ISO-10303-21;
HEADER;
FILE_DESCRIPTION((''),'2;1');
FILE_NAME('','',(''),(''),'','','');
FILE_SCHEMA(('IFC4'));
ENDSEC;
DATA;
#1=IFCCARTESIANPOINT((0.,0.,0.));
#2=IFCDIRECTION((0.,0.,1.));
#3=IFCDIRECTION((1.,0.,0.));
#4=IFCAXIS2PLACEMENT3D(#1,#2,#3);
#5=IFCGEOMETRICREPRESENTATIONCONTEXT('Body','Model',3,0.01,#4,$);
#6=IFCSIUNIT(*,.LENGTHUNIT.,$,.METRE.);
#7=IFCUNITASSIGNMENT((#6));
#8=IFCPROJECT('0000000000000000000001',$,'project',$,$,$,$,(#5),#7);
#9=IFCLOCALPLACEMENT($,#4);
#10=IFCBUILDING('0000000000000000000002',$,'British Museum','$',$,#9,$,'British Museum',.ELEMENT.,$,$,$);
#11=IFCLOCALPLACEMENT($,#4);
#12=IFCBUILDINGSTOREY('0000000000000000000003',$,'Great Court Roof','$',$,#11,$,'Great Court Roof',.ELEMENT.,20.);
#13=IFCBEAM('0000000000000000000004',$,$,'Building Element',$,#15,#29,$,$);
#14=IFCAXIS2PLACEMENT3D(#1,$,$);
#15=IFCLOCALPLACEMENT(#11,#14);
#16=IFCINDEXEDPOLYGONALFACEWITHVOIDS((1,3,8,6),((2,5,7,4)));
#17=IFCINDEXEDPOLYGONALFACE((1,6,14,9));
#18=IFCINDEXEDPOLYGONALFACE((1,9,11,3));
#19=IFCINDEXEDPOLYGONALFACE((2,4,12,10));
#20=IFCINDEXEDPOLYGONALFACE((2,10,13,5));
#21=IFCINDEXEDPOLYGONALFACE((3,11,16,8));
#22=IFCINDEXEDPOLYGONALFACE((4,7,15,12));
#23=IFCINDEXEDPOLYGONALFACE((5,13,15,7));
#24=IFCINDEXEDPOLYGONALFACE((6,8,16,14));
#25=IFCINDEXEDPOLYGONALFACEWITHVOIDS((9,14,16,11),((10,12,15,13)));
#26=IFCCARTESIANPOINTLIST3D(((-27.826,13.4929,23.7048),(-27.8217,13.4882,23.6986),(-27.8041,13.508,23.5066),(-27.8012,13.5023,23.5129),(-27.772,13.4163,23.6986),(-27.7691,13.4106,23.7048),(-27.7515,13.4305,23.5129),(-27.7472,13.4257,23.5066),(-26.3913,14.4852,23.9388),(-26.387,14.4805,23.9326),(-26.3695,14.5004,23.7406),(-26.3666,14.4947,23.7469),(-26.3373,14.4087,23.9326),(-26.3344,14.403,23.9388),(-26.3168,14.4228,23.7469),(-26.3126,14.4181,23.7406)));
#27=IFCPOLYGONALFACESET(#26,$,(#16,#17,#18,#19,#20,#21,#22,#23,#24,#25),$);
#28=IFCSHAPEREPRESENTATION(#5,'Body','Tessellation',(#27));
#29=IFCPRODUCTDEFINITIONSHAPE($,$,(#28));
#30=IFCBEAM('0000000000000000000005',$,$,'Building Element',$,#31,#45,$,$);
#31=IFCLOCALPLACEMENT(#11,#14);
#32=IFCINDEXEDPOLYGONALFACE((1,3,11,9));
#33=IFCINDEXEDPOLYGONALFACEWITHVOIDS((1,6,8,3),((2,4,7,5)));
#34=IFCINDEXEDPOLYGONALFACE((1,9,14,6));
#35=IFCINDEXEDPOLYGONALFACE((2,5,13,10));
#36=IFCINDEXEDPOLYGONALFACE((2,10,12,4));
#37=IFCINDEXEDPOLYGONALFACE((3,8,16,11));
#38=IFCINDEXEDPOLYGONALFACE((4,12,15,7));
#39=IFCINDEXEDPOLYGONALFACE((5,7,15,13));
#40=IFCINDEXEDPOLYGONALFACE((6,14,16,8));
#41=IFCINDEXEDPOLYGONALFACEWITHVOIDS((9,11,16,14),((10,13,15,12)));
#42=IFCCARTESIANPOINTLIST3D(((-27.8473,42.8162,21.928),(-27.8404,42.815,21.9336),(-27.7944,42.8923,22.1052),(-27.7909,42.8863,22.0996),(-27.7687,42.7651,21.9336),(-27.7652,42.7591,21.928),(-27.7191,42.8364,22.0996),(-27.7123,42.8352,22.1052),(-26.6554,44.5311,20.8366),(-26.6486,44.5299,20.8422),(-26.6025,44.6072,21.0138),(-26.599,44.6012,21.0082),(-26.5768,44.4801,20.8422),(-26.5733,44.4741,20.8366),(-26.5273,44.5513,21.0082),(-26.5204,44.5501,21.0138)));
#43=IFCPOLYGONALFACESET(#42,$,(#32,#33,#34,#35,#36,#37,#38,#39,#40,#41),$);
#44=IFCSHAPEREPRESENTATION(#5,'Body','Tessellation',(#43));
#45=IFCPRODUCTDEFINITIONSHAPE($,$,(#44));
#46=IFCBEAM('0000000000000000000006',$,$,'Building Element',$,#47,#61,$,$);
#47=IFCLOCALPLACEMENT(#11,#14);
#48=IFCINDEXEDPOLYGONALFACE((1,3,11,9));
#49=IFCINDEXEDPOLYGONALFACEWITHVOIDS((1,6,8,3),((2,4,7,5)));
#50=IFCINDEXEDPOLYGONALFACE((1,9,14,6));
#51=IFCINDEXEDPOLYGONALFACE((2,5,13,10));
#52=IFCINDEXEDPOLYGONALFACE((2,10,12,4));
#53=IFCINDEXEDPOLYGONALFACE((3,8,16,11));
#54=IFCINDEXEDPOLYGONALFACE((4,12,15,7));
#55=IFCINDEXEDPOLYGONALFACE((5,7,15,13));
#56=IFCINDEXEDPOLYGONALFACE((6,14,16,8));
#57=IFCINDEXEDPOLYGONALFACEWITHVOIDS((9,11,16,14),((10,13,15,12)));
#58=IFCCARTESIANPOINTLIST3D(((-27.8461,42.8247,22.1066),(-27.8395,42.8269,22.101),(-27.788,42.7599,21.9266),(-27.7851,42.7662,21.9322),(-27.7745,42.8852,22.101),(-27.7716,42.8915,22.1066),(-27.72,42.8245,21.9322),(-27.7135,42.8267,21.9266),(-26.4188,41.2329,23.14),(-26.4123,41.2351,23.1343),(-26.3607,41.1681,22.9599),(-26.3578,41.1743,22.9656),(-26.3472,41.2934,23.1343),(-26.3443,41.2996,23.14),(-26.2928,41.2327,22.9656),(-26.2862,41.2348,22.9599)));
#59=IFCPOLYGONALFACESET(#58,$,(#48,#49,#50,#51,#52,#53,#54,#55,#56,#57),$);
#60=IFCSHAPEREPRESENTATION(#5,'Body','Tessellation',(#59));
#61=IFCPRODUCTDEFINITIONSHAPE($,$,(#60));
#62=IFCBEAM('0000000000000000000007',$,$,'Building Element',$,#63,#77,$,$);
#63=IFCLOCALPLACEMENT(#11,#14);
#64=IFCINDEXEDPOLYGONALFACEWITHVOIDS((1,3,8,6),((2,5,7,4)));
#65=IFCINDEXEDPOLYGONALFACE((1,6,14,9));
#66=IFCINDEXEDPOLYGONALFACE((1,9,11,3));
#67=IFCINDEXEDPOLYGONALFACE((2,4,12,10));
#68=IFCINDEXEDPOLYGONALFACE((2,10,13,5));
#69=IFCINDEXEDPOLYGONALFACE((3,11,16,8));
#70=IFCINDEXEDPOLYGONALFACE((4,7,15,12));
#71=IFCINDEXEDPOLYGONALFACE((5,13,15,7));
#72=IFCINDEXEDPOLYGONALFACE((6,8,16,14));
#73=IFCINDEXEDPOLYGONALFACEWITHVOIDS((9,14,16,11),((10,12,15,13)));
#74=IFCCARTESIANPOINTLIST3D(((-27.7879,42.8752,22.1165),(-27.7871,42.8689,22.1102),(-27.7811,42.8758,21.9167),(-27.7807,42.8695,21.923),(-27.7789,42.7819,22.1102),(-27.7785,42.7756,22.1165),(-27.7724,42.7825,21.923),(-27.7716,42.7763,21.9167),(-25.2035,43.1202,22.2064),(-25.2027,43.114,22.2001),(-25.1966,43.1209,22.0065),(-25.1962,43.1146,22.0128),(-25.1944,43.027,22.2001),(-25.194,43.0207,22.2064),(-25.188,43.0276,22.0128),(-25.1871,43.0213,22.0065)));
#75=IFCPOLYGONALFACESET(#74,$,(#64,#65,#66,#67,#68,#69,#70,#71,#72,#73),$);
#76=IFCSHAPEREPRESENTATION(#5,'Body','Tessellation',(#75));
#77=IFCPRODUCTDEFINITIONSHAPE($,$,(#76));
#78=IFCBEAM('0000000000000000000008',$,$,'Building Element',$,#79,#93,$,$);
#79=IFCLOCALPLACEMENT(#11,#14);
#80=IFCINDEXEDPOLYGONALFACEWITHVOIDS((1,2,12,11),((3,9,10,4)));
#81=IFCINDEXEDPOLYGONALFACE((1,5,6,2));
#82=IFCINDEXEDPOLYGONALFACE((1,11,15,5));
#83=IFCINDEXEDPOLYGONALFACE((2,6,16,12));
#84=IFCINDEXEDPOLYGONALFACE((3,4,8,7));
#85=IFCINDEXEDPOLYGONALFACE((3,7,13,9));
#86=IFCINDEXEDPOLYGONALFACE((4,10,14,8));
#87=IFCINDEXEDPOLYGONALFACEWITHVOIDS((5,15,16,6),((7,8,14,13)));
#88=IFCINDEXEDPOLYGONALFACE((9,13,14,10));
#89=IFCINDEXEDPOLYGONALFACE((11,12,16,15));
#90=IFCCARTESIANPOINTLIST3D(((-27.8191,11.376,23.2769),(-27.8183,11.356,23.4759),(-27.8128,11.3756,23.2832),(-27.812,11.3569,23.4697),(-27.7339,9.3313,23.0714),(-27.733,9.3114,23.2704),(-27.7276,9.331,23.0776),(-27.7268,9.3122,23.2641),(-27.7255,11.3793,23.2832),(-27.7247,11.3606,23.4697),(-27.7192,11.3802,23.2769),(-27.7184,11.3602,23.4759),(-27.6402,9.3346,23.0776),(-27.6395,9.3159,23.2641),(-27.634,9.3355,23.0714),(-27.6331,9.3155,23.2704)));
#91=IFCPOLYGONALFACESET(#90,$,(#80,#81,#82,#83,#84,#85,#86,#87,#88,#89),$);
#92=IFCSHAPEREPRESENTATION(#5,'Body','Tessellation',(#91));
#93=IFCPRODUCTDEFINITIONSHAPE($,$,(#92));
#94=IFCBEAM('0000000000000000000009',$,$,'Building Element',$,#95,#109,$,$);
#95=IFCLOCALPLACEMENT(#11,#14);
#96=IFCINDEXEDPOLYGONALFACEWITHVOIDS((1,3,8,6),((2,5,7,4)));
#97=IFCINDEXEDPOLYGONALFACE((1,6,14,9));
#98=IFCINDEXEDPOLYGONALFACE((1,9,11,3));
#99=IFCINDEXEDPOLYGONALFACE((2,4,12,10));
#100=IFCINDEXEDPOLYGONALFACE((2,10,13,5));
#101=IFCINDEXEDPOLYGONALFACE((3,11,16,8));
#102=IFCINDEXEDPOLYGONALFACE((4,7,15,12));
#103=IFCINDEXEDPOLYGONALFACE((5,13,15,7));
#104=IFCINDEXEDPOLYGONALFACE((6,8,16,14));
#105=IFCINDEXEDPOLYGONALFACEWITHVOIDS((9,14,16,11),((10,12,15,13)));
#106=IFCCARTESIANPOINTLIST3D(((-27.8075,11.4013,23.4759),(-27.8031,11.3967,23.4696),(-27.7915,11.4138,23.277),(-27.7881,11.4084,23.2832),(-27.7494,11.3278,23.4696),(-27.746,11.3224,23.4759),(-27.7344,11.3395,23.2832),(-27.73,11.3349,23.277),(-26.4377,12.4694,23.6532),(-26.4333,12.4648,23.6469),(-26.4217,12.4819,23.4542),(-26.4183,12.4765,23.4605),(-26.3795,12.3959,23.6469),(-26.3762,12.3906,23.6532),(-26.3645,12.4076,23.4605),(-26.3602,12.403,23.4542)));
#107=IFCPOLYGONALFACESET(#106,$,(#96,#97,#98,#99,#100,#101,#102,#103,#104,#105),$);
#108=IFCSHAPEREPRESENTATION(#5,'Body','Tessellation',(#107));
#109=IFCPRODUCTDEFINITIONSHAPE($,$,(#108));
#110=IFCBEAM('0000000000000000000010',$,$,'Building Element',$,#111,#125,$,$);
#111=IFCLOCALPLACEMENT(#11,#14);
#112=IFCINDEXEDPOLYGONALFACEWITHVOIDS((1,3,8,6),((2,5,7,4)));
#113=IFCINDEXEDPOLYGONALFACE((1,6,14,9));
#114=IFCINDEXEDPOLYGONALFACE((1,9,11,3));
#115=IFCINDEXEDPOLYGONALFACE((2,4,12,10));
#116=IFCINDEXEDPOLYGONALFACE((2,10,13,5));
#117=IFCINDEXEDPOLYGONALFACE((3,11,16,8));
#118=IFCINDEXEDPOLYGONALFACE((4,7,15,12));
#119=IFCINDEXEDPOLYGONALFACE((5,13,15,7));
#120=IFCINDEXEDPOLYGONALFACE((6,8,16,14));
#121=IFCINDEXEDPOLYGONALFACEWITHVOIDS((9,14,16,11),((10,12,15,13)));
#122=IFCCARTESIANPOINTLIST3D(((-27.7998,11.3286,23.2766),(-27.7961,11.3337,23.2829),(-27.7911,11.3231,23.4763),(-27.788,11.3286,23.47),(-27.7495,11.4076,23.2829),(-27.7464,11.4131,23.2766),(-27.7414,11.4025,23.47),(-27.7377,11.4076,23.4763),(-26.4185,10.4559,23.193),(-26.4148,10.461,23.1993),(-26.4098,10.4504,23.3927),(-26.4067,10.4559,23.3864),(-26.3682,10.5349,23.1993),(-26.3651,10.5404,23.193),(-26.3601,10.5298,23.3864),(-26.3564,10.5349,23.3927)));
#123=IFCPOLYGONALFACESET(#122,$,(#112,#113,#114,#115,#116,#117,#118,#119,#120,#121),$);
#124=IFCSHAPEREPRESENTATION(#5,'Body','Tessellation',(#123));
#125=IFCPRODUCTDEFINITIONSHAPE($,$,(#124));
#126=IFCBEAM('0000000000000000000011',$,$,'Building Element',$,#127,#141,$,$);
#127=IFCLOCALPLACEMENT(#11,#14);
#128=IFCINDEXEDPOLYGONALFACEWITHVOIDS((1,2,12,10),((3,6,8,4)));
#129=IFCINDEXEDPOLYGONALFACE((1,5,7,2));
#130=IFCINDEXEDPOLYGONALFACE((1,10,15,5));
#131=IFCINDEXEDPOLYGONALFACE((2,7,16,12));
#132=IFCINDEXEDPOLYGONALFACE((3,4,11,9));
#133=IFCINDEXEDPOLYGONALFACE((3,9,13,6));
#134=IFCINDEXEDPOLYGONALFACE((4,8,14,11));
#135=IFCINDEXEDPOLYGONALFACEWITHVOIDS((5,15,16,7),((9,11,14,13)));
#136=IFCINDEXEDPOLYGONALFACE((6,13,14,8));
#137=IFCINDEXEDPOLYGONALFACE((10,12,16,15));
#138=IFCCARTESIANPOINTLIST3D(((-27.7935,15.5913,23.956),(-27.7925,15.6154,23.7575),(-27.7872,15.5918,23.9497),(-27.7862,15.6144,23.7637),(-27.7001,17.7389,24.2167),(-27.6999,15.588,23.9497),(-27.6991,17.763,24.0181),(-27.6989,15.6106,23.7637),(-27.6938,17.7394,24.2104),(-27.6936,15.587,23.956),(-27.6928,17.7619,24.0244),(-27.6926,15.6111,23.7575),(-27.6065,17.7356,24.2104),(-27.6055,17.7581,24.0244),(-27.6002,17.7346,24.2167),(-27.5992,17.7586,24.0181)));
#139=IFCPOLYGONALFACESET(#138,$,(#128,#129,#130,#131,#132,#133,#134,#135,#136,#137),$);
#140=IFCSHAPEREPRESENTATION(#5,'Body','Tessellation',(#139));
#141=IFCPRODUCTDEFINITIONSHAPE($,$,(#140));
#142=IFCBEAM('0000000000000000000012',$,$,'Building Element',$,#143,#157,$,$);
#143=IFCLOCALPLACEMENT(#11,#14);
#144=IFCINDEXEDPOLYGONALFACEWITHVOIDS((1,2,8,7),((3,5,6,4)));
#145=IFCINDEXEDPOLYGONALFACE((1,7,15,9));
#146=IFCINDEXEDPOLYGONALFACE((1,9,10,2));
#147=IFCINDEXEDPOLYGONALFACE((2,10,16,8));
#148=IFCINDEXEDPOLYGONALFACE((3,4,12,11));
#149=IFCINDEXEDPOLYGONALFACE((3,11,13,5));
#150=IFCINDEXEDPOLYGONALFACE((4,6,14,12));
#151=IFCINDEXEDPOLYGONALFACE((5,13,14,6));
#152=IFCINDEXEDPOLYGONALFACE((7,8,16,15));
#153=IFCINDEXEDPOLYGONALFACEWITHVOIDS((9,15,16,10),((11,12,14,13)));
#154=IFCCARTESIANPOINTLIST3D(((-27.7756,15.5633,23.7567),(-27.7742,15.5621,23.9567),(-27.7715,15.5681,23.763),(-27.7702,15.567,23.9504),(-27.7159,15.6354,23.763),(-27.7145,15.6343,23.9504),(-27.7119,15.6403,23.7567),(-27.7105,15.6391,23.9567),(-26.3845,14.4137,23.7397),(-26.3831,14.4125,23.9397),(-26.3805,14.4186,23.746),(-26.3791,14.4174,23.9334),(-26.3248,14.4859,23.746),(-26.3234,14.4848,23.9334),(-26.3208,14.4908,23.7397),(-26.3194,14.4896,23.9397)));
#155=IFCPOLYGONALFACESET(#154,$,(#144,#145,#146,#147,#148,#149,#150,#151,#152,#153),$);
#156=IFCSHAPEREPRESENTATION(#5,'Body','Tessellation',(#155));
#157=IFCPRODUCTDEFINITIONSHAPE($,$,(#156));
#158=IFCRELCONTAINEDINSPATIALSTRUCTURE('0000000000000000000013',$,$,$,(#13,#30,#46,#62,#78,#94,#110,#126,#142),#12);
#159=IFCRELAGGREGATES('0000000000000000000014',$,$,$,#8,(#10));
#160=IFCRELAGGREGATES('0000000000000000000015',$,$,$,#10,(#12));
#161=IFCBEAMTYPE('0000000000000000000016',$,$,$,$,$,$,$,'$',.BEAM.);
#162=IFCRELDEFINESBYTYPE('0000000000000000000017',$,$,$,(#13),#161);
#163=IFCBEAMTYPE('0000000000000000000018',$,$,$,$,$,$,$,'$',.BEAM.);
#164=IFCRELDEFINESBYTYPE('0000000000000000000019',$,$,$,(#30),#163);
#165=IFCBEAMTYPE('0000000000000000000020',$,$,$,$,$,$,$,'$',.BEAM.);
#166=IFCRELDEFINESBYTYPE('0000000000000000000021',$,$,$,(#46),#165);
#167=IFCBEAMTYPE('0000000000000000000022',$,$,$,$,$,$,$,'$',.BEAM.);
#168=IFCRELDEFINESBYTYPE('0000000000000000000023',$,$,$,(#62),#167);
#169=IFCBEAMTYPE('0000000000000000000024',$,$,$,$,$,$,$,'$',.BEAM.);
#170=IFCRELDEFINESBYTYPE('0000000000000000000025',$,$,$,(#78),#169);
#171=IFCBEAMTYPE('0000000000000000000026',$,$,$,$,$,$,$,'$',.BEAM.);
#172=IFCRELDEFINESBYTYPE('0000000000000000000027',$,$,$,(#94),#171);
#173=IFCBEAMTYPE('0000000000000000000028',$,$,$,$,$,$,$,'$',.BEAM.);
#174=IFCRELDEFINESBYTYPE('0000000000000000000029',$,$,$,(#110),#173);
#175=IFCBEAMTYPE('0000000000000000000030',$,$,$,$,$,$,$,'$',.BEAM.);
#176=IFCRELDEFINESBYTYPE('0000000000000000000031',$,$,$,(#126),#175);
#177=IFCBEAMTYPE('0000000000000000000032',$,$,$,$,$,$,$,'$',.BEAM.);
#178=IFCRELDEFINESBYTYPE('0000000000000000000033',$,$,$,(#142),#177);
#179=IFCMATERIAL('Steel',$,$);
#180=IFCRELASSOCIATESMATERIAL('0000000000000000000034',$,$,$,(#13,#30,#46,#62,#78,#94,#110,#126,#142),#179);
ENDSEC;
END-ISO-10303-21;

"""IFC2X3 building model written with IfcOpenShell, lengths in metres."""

from ifc_helpers import new_model, si_unit, frame, origin_with_axes, origin_2d, place, context, project, spatial, hollow_rectangle, extrude, material, type_object, element, save


model = new_model("IFC2X3")

# Units and contexts
model_context = context("Model", 3, precision=0.01, world=origin_with_axes(), identifier="Body")
ifc_project = project(units=[si_unit("LENGTHUNIT", "METRE")], contexts=[model_context])

# Building, storey
building_placement = place(None, origin_with_axes())
building = spatial("IfcBuilding", under=ifc_project, at=building_placement, Name="British Museum", Description="$", LongName="British Museum", CompositionType="ELEMENT")
storey_placement = place(None, origin_with_axes())
storey = spatial("IfcBuildingStorey", under=building, at=storey_placement, Name="Great Court Roof", Description="$", LongName="Great Court Roof", CompositionType="ELEMENT", Elevation=20.0)

# Beams
ifc_material = material(Name="Steel")
beam_type_1 = type_object("IfcBeamType", ElementType="$", PredefinedType="BEAM")
beam_1_placement = place(None, origin_with_axes())
element("IfcBeam", 1, at=beam_1_placement, inside=storey, type_object=beam_type_1, material=ifc_material, Description="Building Element", context=model_context, shape_type="SweptSolid", body=[
    extrude(hollow_rectangle(XDim=0.1, YDim=0.2, WallThickness=0.0063, InnerFilletRadius=0.0, OuterFilletRadius=0.0, at=origin_2d()), frame((-27.7866, 13.4593, 23.6057), z_axis=(0.815111, 0.563842, 0.132954), x_axis=(-0.568892, 0.822412, 0.0)), (0.0, 0.0, 1.0), 1.76),
])
beam_type_2 = type_object("IfcBeamType", ElementType="$", PredefinedType="BEAM")
beam_2_placement = place(None, origin_with_axes())
element("IfcBeam", 2, at=beam_2_placement, inside=storey, type_object=beam_type_2, material=ifc_material, Description="Building Element", context=model_context, shape_type="SweptSolid", body=[
    extrude(hollow_rectangle(XDim=0.1, YDim=0.2, WallThickness=0.0063, InnerFilletRadius=0.0, OuterFilletRadius=0.0, at=origin_2d()), frame((-27.7798, 42.8257, 22.0166), z_axis=(0.5058, 0.727767, -0.463165), x_axis=(-0.821155, 0.570705, 0.0)), (0.0, 0.0, 1.0), 2.3564),
])
beam_type_3 = type_object("IfcBeamType", ElementType="$", PredefinedType="BEAM")
beam_3_placement = place(None, origin_with_axes())
element("IfcBeam", 3, at=beam_3_placement, inside=storey, type_object=beam_type_3, material=ifc_material, Description="Building Element", context=model_context, shape_type="SweptSolid", body=[
    extrude(hollow_rectangle(XDim=0.1, YDim=0.2, WallThickness=0.0063, InnerFilletRadius=0.0, OuterFilletRadius=0.0, at=origin_2d()), frame((-27.7798, 42.8257, 22.0166), z_axis=(0.601049, -0.670356, 0.435157), x_axis=(0.744547, 0.66757, 0.0)), (0.0, 0.0, 1.0), 2.3746),
])
beam_type_4 = type_object("IfcBeamType", ElementType="$", PredefinedType="BEAM")
beam_4_placement = place(None, origin_with_axes())
element("IfcBeam", 4, at=beam_4_placement, inside=storey, type_object=beam_type_4, material=ifc_material, Description="Building Element", context=model_context, shape_type="SweptSolid", body=[
    extrude(hollow_rectangle(XDim=0.1, YDim=0.2, WallThickness=0.0063, InnerFilletRadius=0.0, OuterFilletRadius=0.0, at=origin_2d()), frame((-27.7798, 42.8257, 22.0166), z_axis=(0.994939, 0.094341, 0.034588), x_axis=(-0.094398, 0.995535, 0.0)), (0.0, 0.0, 1.0), 2.5976),
])
beam_type_5 = type_object("IfcBeamType", ElementType="$", PredefinedType="BEAM")
beam_5_placement = place(None, origin_with_axes())
element("IfcBeam", 5, at=beam_5_placement, inside=storey, type_object=beam_type_5, material=ifc_material, Description="Building Element", context=model_context, shape_type="SweptSolid", body=[
    extrude(hollow_rectangle(XDim=0.1, YDim=0.2, WallThickness=0.0063, InnerFilletRadius=0.0, OuterFilletRadius=0.0, at=origin_2d()), frame((-27.7688, 11.3681, 23.3764), z_axis=(0.041446, -0.99413, -0.099943), x_axis=(0.999132, 0.041655, 0.0)), (0.0, 0.0, 1.0), 2.0568),
])
beam_type_6 = type_object("IfcBeamType", ElementType="$", PredefinedType="BEAM")
beam_6_placement = place(None, origin_with_axes())
element("IfcBeam", 6, at=beam_6_placement, inside=storey, type_object=beam_type_6, material=ifc_material, Description="Building Element", context=model_context, shape_type="SweptSolid", body=[
    extrude(hollow_rectangle(XDim=0.1, YDim=0.2, WallThickness=0.0063, InnerFilletRadius=0.0, OuterFilletRadius=0.0, at=origin_2d()), frame((-27.7688, 11.3681, 23.3764), z_axis=(0.784525, 0.611728, 0.101538), x_axis=(-0.614906, 0.7886, 0.0)), (0.0, 0.0, 1.0), 1.7461),
])
beam_type_7 = type_object("IfcBeamType", ElementType="$", PredefinedType="BEAM")
beam_7_placement = place(None, origin_with_axes())
element("IfcBeam", 7, at=beam_7_placement, inside=storey, type_object=beam_type_7, material=ifc_material, Description="Building Element", context=model_context, shape_type="SweptSolid", body=[
    extrude(hollow_rectangle(XDim=0.1, YDim=0.2, WallThickness=0.0063, InnerFilletRadius=0.0, OuterFilletRadius=0.0, at=origin_2d()), frame((-27.7688, 11.3681, 23.3764), z_axis=(0.8443, -0.533429, -0.051102), x_axis=(0.534127, 0.845404, 0.0)), (0.0, 0.0, 1.0), 1.636),
])
beam_type_8 = type_object("IfcBeamType", ElementType="$", PredefinedType="BEAM")
beam_8_placement = place(None, origin_with_axes())
element("IfcBeam", 8, at=beam_8_placement, inside=storey, type_object=beam_type_8, material=ifc_material, Description="Building Element", context=model_context, shape_type="SweptSolid", body=[
    extrude(hollow_rectangle(XDim=0.1, YDim=0.2, WallThickness=0.0063, InnerFilletRadius=0.0, OuterFilletRadius=0.0, at=origin_2d()), frame((-27.743, 15.6012, 23.8567), z_axis=(0.043122, 0.99179, 0.120387), x_axis=(-0.999056, 0.043438, 0.0)), (0.0, 0.0, 1.0), 2.1653),
])
beam_type_9 = type_object("IfcBeamType", ElementType="$", PredefinedType="BEAM")
beam_9_placement = place(None, origin_with_axes())
element("IfcBeam", 9, at=beam_9_placement, inside=storey, type_object=beam_type_9, material=ifc_material, Description="Building Element", context=model_context, shape_type="SweptSolid", body=[
    extrude(hollow_rectangle(XDim=0.1, YDim=0.2, WallThickness=0.0063, InnerFilletRadius=0.0, OuterFilletRadius=0.0, at=origin_2d()), frame((-27.743, 15.6012, 23.8567), z_axis=(0.770831, -0.63697, -0.009416), x_axis=(0.636998, 0.770866, 0.0)), (0.0, 0.0, 1.0), 1.8047),
])

save(model, "model.ifc")
